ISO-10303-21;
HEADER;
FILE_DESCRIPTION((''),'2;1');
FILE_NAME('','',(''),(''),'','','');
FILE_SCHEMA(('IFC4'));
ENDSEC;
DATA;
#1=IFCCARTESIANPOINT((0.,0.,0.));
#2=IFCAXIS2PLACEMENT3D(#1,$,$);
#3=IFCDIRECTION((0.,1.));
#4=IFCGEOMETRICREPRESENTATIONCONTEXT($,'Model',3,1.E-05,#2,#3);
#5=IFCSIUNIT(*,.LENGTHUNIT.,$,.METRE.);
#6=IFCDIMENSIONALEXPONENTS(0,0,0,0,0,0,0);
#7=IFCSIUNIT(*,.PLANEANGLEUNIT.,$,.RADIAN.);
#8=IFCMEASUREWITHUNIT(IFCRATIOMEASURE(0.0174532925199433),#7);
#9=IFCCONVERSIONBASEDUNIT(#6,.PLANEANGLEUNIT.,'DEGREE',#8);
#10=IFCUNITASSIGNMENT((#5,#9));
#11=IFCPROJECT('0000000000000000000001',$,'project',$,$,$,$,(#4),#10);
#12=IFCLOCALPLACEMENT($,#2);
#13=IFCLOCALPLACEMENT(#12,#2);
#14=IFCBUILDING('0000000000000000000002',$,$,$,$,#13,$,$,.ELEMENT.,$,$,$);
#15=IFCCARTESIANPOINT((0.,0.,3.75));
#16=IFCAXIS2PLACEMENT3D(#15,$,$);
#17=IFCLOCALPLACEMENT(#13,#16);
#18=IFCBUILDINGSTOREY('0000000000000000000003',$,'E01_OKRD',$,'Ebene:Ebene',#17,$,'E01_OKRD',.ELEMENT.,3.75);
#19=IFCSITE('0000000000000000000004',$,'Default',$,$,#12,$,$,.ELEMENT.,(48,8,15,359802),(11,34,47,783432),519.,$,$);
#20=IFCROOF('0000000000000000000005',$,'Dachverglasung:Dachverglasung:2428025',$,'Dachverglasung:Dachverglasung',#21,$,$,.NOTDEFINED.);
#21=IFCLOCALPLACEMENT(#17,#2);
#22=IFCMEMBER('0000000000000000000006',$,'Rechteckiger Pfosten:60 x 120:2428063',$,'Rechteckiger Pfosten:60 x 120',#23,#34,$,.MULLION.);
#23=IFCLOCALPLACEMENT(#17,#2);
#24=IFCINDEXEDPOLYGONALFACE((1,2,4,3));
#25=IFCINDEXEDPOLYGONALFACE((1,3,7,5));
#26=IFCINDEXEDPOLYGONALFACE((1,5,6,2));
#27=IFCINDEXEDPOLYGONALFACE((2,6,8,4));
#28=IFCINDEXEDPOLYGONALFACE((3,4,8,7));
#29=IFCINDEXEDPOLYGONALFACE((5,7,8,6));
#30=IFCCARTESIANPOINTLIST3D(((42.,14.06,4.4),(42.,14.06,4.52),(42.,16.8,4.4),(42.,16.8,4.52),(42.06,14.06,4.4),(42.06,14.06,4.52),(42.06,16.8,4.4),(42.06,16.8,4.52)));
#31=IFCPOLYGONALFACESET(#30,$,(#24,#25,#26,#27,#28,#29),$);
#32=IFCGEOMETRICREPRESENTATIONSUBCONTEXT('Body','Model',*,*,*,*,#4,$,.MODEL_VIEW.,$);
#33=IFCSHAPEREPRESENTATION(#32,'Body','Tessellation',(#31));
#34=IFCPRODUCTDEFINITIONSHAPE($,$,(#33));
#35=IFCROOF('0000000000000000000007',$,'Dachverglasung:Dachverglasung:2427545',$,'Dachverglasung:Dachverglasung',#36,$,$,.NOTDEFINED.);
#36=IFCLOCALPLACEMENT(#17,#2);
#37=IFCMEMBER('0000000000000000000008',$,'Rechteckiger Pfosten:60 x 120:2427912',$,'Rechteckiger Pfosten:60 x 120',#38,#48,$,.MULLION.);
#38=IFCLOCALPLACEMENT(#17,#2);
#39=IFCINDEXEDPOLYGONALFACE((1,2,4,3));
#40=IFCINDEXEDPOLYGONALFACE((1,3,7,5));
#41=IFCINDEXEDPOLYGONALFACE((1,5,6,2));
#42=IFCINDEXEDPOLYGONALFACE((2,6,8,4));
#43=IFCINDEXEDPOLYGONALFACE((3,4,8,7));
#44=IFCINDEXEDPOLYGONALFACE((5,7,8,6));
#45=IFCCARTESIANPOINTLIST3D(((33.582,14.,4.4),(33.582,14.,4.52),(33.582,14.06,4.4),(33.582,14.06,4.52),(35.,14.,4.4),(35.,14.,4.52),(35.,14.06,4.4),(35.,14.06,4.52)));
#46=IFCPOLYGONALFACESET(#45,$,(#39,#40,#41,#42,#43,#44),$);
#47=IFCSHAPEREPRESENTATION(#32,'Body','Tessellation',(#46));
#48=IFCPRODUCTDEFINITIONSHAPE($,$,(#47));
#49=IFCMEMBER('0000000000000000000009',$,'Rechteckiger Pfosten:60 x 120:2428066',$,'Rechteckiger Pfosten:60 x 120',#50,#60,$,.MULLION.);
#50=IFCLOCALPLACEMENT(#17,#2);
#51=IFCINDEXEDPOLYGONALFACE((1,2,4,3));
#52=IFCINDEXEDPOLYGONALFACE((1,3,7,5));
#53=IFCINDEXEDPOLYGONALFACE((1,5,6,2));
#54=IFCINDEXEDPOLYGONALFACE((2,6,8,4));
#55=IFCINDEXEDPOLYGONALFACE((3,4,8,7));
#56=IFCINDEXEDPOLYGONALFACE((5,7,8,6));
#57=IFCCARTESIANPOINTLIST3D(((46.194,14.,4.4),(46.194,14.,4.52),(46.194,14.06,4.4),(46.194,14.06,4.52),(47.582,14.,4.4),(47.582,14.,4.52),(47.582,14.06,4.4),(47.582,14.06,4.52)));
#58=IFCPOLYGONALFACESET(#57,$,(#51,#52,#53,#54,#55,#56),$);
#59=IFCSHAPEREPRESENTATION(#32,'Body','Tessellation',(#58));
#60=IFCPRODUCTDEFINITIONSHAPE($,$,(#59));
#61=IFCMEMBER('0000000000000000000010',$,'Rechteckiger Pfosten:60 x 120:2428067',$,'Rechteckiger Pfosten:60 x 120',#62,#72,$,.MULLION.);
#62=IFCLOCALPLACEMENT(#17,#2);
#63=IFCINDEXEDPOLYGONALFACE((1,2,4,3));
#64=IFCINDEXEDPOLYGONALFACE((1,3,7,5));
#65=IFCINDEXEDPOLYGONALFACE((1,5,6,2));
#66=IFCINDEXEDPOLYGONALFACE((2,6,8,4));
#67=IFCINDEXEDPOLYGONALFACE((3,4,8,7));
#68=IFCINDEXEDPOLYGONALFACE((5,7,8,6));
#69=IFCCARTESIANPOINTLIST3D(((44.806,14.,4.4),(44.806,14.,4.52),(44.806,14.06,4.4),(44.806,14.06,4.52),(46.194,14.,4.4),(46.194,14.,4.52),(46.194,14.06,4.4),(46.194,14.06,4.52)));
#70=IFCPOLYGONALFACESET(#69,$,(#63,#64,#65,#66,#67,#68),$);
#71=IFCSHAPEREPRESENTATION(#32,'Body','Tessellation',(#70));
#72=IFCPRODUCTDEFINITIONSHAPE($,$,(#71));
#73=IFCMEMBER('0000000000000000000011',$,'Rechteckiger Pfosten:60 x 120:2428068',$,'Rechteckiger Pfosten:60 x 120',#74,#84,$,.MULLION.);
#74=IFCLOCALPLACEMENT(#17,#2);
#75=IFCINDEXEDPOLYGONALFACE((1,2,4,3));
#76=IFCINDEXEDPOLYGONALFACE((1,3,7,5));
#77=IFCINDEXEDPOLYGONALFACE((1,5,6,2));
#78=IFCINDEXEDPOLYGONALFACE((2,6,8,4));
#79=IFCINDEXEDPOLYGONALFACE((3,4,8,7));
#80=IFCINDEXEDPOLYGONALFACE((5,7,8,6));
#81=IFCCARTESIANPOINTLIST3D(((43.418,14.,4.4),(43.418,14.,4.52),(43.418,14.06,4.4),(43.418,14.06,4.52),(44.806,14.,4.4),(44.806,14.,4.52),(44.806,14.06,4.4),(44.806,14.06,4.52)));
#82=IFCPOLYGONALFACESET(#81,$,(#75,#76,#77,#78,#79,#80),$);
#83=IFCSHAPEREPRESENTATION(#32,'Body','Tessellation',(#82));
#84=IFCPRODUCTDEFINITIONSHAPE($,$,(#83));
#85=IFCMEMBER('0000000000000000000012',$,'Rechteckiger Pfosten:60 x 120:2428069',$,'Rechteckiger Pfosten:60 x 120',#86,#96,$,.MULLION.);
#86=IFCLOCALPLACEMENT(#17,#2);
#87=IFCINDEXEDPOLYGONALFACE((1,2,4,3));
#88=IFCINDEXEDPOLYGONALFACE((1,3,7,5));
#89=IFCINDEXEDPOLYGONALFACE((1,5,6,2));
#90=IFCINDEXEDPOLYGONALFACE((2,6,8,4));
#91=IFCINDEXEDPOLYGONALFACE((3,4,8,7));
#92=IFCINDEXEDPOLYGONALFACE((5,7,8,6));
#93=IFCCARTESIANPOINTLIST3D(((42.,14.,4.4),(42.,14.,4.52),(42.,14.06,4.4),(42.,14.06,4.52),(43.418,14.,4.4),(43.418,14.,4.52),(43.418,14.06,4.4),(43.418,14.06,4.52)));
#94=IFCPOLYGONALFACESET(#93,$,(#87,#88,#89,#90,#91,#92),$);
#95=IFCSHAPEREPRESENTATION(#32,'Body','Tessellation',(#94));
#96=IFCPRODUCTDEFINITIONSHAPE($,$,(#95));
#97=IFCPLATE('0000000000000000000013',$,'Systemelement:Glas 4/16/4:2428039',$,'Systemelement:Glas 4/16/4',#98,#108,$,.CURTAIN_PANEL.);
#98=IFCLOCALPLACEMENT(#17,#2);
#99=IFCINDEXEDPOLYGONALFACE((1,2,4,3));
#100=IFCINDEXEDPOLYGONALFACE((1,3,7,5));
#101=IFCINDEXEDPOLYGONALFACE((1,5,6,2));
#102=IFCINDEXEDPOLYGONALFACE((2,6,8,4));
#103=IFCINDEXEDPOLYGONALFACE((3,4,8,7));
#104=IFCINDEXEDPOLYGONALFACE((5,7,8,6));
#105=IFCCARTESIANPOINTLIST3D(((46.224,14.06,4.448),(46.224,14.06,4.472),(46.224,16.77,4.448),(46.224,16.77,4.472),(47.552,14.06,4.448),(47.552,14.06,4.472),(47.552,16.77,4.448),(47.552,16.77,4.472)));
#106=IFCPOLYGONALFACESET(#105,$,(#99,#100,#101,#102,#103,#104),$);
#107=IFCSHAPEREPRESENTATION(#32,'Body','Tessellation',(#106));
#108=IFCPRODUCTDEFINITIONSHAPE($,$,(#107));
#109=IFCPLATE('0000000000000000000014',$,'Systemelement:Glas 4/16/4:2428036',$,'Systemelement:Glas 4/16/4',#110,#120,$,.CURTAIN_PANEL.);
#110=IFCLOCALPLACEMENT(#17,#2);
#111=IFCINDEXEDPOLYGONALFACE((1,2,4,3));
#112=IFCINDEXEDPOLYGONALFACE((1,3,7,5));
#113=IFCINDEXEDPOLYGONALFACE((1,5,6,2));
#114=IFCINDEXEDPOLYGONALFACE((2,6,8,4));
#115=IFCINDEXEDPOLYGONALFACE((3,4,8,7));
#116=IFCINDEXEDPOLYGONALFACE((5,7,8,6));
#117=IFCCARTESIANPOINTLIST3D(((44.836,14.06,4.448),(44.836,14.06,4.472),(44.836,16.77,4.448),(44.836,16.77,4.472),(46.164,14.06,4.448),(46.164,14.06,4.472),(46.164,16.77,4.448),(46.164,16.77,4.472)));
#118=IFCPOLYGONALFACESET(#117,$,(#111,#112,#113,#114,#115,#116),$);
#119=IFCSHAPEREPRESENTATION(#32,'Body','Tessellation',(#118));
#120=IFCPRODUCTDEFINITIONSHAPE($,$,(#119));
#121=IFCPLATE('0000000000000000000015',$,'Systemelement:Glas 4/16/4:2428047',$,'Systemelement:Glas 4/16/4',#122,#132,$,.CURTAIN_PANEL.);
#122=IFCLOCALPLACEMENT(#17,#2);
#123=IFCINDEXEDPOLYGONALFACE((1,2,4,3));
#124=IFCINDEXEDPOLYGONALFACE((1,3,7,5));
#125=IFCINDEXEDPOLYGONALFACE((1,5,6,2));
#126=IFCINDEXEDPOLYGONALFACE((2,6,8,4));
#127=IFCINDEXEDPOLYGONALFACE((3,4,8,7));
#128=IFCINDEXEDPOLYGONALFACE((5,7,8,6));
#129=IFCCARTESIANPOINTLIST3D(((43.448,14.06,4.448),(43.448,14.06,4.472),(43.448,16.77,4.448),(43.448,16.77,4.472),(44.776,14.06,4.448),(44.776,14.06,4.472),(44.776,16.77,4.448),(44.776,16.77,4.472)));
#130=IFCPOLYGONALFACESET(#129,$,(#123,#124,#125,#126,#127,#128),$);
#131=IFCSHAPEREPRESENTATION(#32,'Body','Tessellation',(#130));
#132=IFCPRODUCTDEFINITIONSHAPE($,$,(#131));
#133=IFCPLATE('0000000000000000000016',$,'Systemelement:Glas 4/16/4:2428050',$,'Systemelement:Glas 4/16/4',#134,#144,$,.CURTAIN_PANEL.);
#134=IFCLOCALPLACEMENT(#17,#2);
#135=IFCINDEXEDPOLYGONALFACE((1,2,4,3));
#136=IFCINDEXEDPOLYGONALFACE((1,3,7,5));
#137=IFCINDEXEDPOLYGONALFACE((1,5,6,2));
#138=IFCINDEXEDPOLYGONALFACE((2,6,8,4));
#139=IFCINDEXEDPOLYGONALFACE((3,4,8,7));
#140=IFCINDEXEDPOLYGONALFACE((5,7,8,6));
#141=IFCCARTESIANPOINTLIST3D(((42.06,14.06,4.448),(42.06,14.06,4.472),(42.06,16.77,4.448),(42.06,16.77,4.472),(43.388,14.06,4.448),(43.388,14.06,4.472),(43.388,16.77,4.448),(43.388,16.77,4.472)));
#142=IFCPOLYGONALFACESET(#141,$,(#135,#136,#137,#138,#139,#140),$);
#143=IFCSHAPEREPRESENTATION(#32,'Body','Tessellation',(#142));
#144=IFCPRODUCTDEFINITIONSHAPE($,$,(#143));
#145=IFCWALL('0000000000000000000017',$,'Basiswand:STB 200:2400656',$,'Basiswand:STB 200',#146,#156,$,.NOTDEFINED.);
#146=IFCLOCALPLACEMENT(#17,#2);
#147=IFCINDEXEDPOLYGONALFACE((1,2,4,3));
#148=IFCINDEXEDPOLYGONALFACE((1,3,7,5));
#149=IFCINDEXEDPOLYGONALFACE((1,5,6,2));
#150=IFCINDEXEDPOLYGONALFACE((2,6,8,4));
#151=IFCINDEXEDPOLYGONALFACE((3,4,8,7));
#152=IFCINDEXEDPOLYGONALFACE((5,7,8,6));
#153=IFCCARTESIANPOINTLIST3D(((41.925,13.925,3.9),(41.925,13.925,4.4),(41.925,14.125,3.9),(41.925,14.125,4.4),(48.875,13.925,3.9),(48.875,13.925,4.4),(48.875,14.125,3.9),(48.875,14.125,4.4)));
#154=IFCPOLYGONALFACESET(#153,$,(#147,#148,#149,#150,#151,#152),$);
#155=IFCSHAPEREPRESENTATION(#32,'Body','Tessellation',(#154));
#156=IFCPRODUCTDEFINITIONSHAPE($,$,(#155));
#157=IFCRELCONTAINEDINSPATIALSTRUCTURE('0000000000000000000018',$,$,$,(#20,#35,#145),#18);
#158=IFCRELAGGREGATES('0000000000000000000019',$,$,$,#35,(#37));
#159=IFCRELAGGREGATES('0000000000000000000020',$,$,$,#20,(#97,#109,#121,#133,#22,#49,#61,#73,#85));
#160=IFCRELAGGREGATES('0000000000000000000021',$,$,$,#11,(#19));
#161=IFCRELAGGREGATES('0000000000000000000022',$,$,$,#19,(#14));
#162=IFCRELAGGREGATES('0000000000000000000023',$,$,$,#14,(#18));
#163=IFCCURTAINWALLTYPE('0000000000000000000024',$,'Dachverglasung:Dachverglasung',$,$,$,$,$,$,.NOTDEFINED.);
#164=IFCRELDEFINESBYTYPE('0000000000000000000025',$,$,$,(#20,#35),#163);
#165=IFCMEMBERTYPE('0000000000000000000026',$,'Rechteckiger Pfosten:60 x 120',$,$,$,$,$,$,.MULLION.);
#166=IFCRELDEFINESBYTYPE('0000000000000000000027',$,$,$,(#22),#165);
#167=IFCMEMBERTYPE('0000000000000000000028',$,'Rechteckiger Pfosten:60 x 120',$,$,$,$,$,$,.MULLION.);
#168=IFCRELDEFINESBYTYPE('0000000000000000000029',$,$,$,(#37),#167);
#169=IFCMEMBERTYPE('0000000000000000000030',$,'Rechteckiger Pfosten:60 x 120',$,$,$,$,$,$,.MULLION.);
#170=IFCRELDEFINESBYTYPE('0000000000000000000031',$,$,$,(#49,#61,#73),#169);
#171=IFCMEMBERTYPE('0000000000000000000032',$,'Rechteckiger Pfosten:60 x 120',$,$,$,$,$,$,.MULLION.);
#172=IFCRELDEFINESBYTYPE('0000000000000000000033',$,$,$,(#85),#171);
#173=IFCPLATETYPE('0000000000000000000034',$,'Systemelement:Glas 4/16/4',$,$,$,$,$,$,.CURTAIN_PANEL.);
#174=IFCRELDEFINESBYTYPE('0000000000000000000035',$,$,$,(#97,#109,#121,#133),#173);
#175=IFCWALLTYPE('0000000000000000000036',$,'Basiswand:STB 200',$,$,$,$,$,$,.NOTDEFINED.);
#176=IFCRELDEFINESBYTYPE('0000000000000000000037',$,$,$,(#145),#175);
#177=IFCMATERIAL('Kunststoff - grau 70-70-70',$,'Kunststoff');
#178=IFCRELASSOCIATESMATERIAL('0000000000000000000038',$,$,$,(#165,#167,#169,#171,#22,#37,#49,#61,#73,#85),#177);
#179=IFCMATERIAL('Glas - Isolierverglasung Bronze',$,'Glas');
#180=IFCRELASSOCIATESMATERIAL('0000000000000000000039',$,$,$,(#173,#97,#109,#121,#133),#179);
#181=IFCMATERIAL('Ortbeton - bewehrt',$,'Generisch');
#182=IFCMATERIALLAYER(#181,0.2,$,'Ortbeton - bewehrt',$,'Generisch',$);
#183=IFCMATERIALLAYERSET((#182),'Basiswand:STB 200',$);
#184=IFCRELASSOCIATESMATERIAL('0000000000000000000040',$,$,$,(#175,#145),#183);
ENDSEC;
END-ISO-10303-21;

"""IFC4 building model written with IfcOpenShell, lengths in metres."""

from ifc_helpers import new_model, entity, si_unit, converted_unit, direction, frame, frame_2d, origin, origin_2d_with_axis, place, context, subcontext, project, spatial, rectangle, extrude, shape, source, transform, mapped, material, layer, layer_set, layer_usage, material_profile, profile_set, profile_usage, type_object, type_shapes, element, aggregate, save


model = new_model("IFC4")

# Units and contexts
model_context = context("Model", 3, precision=1e-05, world=origin(), true_north=direction((0.0, 1.0)))
body_context = subcontext(model_context, "Body", "Model", "MODEL_VIEW")
footprint_context = subcontext(model_context, "FootPrint", "Model", "MODEL_VIEW")
ifc_project = project(units=[si_unit("LENGTHUNIT", "METRE"), converted_unit("PLANEANGLEUNIT", "DEGREE", entity("IfcRatioMeasure", 0.0174532925199433), si_unit("PLANEANGLEUNIT", "RADIAN"), dimensions=[0, 0, 0, 0, 0, 0, 0])], contexts=[model_context])

# Site, building, storey
site_placement = place(None, frame((0.0, 0.0, 0.0)))
site = spatial("IfcSite", under=ifc_project, at=site_placement, Name="Default", CompositionType="ELEMENT", RefLatitude=(48, 8, 15, 359802), RefLongitude=(11, 34, 47, 783432), RefElevation=519.0)
building_placement = place(site_placement, origin())
building = spatial("IfcBuilding", under=site, at=building_placement, CompositionType="ELEMENT")
storey_placement = place(building_placement, frame((0.0, 0.0, 3.75)))
storey = spatial("IfcBuildingStorey", under=building, at=storey_placement, Name="E01_OKRD", ObjectType="Ebene:Ebene", LongName="E01_OKRD", CompositionType="ELEMENT", Elevation=3.75)

# Shared definitions
ifc_material_1 = material(Name="Ortbeton - bewehrt", Category="Generisch")

# Roof, member
curtain_wall_type = type_object("IfcCurtainWallType", Name="Dachverglasung:Dachverglasung", PredefinedType="NOTDEFINED")
roof_1_placement = place(storey_placement, frame((0.0, 0.0, -3.75)))
roof_1 = element("IfcRoof", 1, at=roof_1_placement, inside=storey, type_object=curtain_wall_type, Name="Dachverglasung:Dachverglasung:2428025", ObjectType="Dachverglasung:Dachverglasung", PredefinedType="NOTDEFINED")
ifc_material_2 = material(Name="Kunststoff - grau 70-70-70", Category="Kunststoff")
ifc_material_profile_1 = material_profile(ifc_material_2, rectangle(XDim=0.06, YDim=0.12, at=frame_2d((0.0, 0.0), x_axis=(1.0, 0.0))), Name="60 x 120")
ifc_profile_set_1 = profile_set([ifc_material_profile_1], Name="60 x 120")
ifc_profile_usage_1 = profile_usage(ifc_profile_set_1)
member_type_1 = type_object("IfcMemberType", Name="Rechteckiger Pfosten:60 x 120", PredefinedType="MULLION", material=ifc_profile_set_1)
shared_shape_1 = source(origin(), body_context, "Body", "SweptSolid", [
    extrude(rectangle(XDim=0.06, YDim=0.12, at=origin_2d_with_axis()), frame((-0.03, 0.0, -2.74), z_axis=(0.0, 0.0, 1.0), x_axis=(-1.0, 0.0, 0.0)), (0.0, 0.0, 1.0), 2.74),
])
type_shapes(member_type_1, [shared_shape_1])
member_1_placement = place(storey_placement, frame((42.0, 14.06, 4.46), z_axis=(0.0, -1.0, 0.0), x_axis=(-1.0, 0.0, 0.0)))
member_1 = element("IfcMember", 2, at=member_1_placement, type_object=member_type_1, material=ifc_profile_usage_1, Name="Rechteckiger Pfosten:60 x 120:2428063", ObjectType="Rechteckiger Pfosten:60 x 120", PredefinedType="MULLION", context=body_context, shape_type="MappedRepresentation", body=[
    mapped(shared_shape_1, transform((0.0, 0.0, 0.0), scale=1.0)),
])

# Roof, member
roof_2_placement = place(storey_placement, frame((0.0, 0.0, -3.75)))
roof_2 = element("IfcRoof", 3, at=roof_2_placement, inside=storey, type_object=curtain_wall_type, Name="Dachverglasung:Dachverglasung:2427545", ObjectType="Dachverglasung:Dachverglasung", PredefinedType="NOTDEFINED")
ifc_profile_usage_2 = profile_usage(ifc_profile_set_1)
member_type_2 = type_object("IfcMemberType", Name="Rechteckiger Pfosten:60 x 120", PredefinedType="MULLION", material=ifc_profile_set_1)
shared_shape_2 = source(origin(), body_context, "Body", "SweptSolid", [
    extrude(rectangle(XDim=0.06, YDim=0.12, at=origin_2d_with_axis()), frame((-0.03, 0.0, -1.418), z_axis=(0.0, 0.0, 1.0), x_axis=(-1.0, 0.0, 0.0)), (0.0, 0.0, 1.0), 1.418),
])
type_shapes(member_type_2, [shared_shape_2])
member_2_placement = place(storey_placement, frame((35.0, 14.0, 4.46), z_axis=(1.0, 0.0, 0.0), x_axis=(0.0, -1.0, 0.0)))
member_2 = element("IfcMember", 4, at=member_2_placement, type_object=member_type_2, material=ifc_profile_usage_2, Name="Rechteckiger Pfosten:60 x 120:2427912", ObjectType="Rechteckiger Pfosten:60 x 120", PredefinedType="MULLION", context=body_context, shape_type="MappedRepresentation", body=[
    mapped(shared_shape_2, transform((0.0, 0.0, 0.0), scale=1.0)),
])
aggregate(roof_2, [member_2])

# Members
ifc_profile_usage_3 = profile_usage(ifc_profile_set_1)
member_type_3 = type_object("IfcMemberType", Name="Rechteckiger Pfosten:60 x 120", PredefinedType="MULLION", material=ifc_profile_set_1)
shared_shape_3 = source(origin(), body_context, "Body", "SweptSolid", [
    extrude(rectangle(XDim=0.06, YDim=0.12, at=origin_2d_with_axis()), frame((-0.03, 0.0, -1.388), z_axis=(0.0, 0.0, 1.0), x_axis=(-1.0, 0.0, 0.0)), (0.0, 0.0, 1.0), 1.388),
])
type_shapes(member_type_3, [shared_shape_3])
member_3_placement = place(storey_placement, frame((47.582, 14.0, 4.46), z_axis=(1.0, 0.0, 0.0), x_axis=(0.0, -1.0, 0.0)))
member_3 = element("IfcMember", 5, at=member_3_placement, type_object=member_type_3, material=ifc_profile_usage_3, Name="Rechteckiger Pfosten:60 x 120:2428066", ObjectType="Rechteckiger Pfosten:60 x 120", PredefinedType="MULLION", context=body_context, shape_type="MappedRepresentation", body=[
    mapped(shared_shape_3, transform((0.0, 0.0, 0.0), scale=1.0)),
])
ifc_profile_usage_4 = profile_usage(ifc_profile_set_1)
member_4_placement = place(storey_placement, frame((46.194, 14.0, 4.46), z_axis=(1.0, 0.0, 0.0), x_axis=(0.0, -1.0, 0.0)))
member_4 = element("IfcMember", 6, at=member_4_placement, type_object=member_type_3, material=ifc_profile_usage_4, Name="Rechteckiger Pfosten:60 x 120:2428067", ObjectType="Rechteckiger Pfosten:60 x 120", PredefinedType="MULLION", context=body_context, shape_type="MappedRepresentation", body=[
    mapped(shared_shape_3, transform((0.0, 0.0, 0.0), scale=1.0)),
])
ifc_profile_usage_5 = profile_usage(ifc_profile_set_1)
member_5_placement = place(storey_placement, frame((44.806, 14.0, 4.46), z_axis=(1.0, 0.0, 0.0), x_axis=(0.0, -1.0, 0.0)))
member_5 = element("IfcMember", 7, at=member_5_placement, type_object=member_type_3, material=ifc_profile_usage_5, Name="Rechteckiger Pfosten:60 x 120:2428068", ObjectType="Rechteckiger Pfosten:60 x 120", PredefinedType="MULLION", context=body_context, shape_type="MappedRepresentation", body=[
    mapped(shared_shape_3, transform((0.0, 0.0, 0.0), scale=1.0)),
])
ifc_profile_usage_6 = profile_usage(ifc_profile_set_1)
member_type_4 = type_object("IfcMemberType", Name="Rechteckiger Pfosten:60 x 120", PredefinedType="MULLION", material=ifc_profile_set_1)
shared_shape_4 = source(origin(), body_context, "Body", "SweptSolid", [
    extrude(rectangle(XDim=0.06, YDim=0.12, at=origin_2d_with_axis()), frame((-0.03, 0.0, -1.418), z_axis=(0.0, 0.0, 1.0), x_axis=(-1.0, 0.0, 0.0)), (0.0, 0.0, 1.0), 1.418),
])
type_shapes(member_type_4, [shared_shape_4])
member_6_placement = place(storey_placement, frame((43.418, 14.0, 4.46), z_axis=(1.0, 0.0, 0.0), x_axis=(0.0, -1.0, 0.0)))
member_6 = element("IfcMember", 8, at=member_6_placement, type_object=member_type_4, material=ifc_profile_usage_6, Name="Rechteckiger Pfosten:60 x 120:2428069", ObjectType="Rechteckiger Pfosten:60 x 120", PredefinedType="MULLION", context=body_context, shape_type="MappedRepresentation", body=[
    mapped(shared_shape_4, transform((0.0, 0.0, 0.0), scale=1.0)),
])

# Plates
ifc_material_3 = material(Name="Glas - Isolierverglasung Bronze", Category="Glas")
plate_type = type_object("IfcPlateType", Name="Systemelement:Glas 4/16/4", PredefinedType="CURTAIN_PANEL", material=ifc_material_3)
shared_shape_5 = source(origin(), body_context, "Body", "SweptSolid", [
    extrude(rectangle(XDim=0.024, YDim=2.71, at=origin_2d_with_axis()), frame((0.0, 0.0, 0.0), z_axis=(0.0, 0.0, 1.0), x_axis=(0.0, 1.0, 0.0)), (0.0, 0.0, 1.0), 1.328),
])
cartesian_point = entity("IfcCartesianPoint", [1.355, -0.012])
shared_shape_6 = source(origin(), footprint_context, "FootPrint", "Curve2D", [
    entity("IfcPolyline", [cartesian_point, entity("IfcCartesianPoint", [1.355, 0.012]), entity("IfcCartesianPoint", [-1.355, 0.012]), entity("IfcCartesianPoint", [-1.355, -0.012]), cartesian_point]),
])
type_shapes(plate_type, [shared_shape_5, shared_shape_6])
plate_1_placement = place(roof_1_placement, frame((47.552, 15.415, 8.21), z_axis=(-1.0, 0.0, 0.0), x_axis=(0.0, 1.0, 0.0)))
plate_1 = element("IfcPlate", 9, at=plate_1_placement, type_object=plate_type, material=ifc_material_3, Name="Systemelement:Glas 4/16/4:2428039", ObjectType="Systemelement:Glas 4/16/4", PredefinedType="CURTAIN_PANEL", shapes=[
    shape(body_context, "Body", "MappedRepresentation", [mapped(shared_shape_5, transform((0.0, 0.0, 0.0), scale=1.0))]),
    shape(body_context, "Body", "MappedRepresentation", [mapped(shared_shape_6, transform((0.0, 0.0, 0.0), scale=1.0))]),
])
plate_2_placement = place(roof_1_placement, frame((46.164, 15.415, 8.21), z_axis=(-1.0, 0.0, 0.0), x_axis=(0.0, 1.0, 0.0)))
plate_2 = element("IfcPlate", 10, at=plate_2_placement, type_object=plate_type, material=ifc_material_3, Name="Systemelement:Glas 4/16/4:2428036", ObjectType="Systemelement:Glas 4/16/4", PredefinedType="CURTAIN_PANEL", shapes=[
    shape(body_context, "Body", "MappedRepresentation", [mapped(shared_shape_5, transform((0.0, 0.0, 0.0), scale=1.0))]),
    shape(body_context, "Body", "MappedRepresentation", [mapped(shared_shape_6, transform((0.0, 0.0, 0.0), scale=1.0))]),
])
plate_3_placement = place(roof_1_placement, frame((44.776, 15.415, 8.21), z_axis=(-1.0, 0.0, 0.0), x_axis=(0.0, 1.0, 0.0)))
plate_3 = element("IfcPlate", 11, at=plate_3_placement, type_object=plate_type, material=ifc_material_3, Name="Systemelement:Glas 4/16/4:2428047", ObjectType="Systemelement:Glas 4/16/4", PredefinedType="CURTAIN_PANEL", shapes=[
    shape(body_context, "Body", "MappedRepresentation", [mapped(shared_shape_5, transform((0.0, 0.0, 0.0), scale=1.0))]),
    shape(body_context, "Body", "MappedRepresentation", [mapped(shared_shape_6, transform((0.0, 0.0, 0.0), scale=1.0))]),
])
plate_4_placement = place(roof_1_placement, frame((43.388, 15.415, 8.21), z_axis=(-1.0, 0.0, 0.0), x_axis=(0.0, 1.0, 0.0)))
plate_4 = element("IfcPlate", 12, at=plate_4_placement, type_object=plate_type, material=ifc_material_3, Name="Systemelement:Glas 4/16/4:2428050", ObjectType="Systemelement:Glas 4/16/4", PredefinedType="CURTAIN_PANEL", shapes=[
    shape(body_context, "Body", "MappedRepresentation", [mapped(shared_shape_5, transform((0.0, 0.0, 0.0), scale=1.0))]),
    shape(body_context, "Body", "MappedRepresentation", [mapped(shared_shape_6, transform((0.0, 0.0, 0.0), scale=1.0))]),
])
aggregate(roof_1, [plate_1, plate_2, plate_3, plate_4, member_1, member_3, member_4, member_5, member_6])

# Wall
ifc_layer_1 = layer(ifc_material_1, 0.2, Name="Ortbeton - bewehrt", Category="Generisch")
ifc_layer_set_1 = layer_set([ifc_layer_1], Name="Basiswand:STB 200")
ifc_layer_usage_1 = layer_usage(ifc_layer_set_1, "AXIS2", "NEGATIVE", 0.1)
wall_type_1 = type_object("IfcWallType", Name="Basiswand:STB 200", PredefinedType="NOTDEFINED", material=ifc_layer_set_1)
wall_1_placement = place(storey_placement, frame((48.875, 14.025, 3.9), z_axis=(0.0, 0.0, 1.0), x_axis=(-1.0, 0.0, 0.0)))
element("IfcWall", 13, at=wall_1_placement, inside=storey, type_object=wall_type_1, material=ifc_layer_usage_1, Name="Basiswand:STB 200:2400656", ObjectType="Basiswand:STB 200", PredefinedType="NOTDEFINED", context=body_context, shape_type="SweptSolid", body=[
    extrude(rectangle(XDim=6.95, YDim=0.2, at=frame_2d((3.475, 0.0), x_axis=(-1.0, 0.0))), origin(), (0.0, 0.0, 1.0), 0.5),
])

save(model, "model.ifc")
